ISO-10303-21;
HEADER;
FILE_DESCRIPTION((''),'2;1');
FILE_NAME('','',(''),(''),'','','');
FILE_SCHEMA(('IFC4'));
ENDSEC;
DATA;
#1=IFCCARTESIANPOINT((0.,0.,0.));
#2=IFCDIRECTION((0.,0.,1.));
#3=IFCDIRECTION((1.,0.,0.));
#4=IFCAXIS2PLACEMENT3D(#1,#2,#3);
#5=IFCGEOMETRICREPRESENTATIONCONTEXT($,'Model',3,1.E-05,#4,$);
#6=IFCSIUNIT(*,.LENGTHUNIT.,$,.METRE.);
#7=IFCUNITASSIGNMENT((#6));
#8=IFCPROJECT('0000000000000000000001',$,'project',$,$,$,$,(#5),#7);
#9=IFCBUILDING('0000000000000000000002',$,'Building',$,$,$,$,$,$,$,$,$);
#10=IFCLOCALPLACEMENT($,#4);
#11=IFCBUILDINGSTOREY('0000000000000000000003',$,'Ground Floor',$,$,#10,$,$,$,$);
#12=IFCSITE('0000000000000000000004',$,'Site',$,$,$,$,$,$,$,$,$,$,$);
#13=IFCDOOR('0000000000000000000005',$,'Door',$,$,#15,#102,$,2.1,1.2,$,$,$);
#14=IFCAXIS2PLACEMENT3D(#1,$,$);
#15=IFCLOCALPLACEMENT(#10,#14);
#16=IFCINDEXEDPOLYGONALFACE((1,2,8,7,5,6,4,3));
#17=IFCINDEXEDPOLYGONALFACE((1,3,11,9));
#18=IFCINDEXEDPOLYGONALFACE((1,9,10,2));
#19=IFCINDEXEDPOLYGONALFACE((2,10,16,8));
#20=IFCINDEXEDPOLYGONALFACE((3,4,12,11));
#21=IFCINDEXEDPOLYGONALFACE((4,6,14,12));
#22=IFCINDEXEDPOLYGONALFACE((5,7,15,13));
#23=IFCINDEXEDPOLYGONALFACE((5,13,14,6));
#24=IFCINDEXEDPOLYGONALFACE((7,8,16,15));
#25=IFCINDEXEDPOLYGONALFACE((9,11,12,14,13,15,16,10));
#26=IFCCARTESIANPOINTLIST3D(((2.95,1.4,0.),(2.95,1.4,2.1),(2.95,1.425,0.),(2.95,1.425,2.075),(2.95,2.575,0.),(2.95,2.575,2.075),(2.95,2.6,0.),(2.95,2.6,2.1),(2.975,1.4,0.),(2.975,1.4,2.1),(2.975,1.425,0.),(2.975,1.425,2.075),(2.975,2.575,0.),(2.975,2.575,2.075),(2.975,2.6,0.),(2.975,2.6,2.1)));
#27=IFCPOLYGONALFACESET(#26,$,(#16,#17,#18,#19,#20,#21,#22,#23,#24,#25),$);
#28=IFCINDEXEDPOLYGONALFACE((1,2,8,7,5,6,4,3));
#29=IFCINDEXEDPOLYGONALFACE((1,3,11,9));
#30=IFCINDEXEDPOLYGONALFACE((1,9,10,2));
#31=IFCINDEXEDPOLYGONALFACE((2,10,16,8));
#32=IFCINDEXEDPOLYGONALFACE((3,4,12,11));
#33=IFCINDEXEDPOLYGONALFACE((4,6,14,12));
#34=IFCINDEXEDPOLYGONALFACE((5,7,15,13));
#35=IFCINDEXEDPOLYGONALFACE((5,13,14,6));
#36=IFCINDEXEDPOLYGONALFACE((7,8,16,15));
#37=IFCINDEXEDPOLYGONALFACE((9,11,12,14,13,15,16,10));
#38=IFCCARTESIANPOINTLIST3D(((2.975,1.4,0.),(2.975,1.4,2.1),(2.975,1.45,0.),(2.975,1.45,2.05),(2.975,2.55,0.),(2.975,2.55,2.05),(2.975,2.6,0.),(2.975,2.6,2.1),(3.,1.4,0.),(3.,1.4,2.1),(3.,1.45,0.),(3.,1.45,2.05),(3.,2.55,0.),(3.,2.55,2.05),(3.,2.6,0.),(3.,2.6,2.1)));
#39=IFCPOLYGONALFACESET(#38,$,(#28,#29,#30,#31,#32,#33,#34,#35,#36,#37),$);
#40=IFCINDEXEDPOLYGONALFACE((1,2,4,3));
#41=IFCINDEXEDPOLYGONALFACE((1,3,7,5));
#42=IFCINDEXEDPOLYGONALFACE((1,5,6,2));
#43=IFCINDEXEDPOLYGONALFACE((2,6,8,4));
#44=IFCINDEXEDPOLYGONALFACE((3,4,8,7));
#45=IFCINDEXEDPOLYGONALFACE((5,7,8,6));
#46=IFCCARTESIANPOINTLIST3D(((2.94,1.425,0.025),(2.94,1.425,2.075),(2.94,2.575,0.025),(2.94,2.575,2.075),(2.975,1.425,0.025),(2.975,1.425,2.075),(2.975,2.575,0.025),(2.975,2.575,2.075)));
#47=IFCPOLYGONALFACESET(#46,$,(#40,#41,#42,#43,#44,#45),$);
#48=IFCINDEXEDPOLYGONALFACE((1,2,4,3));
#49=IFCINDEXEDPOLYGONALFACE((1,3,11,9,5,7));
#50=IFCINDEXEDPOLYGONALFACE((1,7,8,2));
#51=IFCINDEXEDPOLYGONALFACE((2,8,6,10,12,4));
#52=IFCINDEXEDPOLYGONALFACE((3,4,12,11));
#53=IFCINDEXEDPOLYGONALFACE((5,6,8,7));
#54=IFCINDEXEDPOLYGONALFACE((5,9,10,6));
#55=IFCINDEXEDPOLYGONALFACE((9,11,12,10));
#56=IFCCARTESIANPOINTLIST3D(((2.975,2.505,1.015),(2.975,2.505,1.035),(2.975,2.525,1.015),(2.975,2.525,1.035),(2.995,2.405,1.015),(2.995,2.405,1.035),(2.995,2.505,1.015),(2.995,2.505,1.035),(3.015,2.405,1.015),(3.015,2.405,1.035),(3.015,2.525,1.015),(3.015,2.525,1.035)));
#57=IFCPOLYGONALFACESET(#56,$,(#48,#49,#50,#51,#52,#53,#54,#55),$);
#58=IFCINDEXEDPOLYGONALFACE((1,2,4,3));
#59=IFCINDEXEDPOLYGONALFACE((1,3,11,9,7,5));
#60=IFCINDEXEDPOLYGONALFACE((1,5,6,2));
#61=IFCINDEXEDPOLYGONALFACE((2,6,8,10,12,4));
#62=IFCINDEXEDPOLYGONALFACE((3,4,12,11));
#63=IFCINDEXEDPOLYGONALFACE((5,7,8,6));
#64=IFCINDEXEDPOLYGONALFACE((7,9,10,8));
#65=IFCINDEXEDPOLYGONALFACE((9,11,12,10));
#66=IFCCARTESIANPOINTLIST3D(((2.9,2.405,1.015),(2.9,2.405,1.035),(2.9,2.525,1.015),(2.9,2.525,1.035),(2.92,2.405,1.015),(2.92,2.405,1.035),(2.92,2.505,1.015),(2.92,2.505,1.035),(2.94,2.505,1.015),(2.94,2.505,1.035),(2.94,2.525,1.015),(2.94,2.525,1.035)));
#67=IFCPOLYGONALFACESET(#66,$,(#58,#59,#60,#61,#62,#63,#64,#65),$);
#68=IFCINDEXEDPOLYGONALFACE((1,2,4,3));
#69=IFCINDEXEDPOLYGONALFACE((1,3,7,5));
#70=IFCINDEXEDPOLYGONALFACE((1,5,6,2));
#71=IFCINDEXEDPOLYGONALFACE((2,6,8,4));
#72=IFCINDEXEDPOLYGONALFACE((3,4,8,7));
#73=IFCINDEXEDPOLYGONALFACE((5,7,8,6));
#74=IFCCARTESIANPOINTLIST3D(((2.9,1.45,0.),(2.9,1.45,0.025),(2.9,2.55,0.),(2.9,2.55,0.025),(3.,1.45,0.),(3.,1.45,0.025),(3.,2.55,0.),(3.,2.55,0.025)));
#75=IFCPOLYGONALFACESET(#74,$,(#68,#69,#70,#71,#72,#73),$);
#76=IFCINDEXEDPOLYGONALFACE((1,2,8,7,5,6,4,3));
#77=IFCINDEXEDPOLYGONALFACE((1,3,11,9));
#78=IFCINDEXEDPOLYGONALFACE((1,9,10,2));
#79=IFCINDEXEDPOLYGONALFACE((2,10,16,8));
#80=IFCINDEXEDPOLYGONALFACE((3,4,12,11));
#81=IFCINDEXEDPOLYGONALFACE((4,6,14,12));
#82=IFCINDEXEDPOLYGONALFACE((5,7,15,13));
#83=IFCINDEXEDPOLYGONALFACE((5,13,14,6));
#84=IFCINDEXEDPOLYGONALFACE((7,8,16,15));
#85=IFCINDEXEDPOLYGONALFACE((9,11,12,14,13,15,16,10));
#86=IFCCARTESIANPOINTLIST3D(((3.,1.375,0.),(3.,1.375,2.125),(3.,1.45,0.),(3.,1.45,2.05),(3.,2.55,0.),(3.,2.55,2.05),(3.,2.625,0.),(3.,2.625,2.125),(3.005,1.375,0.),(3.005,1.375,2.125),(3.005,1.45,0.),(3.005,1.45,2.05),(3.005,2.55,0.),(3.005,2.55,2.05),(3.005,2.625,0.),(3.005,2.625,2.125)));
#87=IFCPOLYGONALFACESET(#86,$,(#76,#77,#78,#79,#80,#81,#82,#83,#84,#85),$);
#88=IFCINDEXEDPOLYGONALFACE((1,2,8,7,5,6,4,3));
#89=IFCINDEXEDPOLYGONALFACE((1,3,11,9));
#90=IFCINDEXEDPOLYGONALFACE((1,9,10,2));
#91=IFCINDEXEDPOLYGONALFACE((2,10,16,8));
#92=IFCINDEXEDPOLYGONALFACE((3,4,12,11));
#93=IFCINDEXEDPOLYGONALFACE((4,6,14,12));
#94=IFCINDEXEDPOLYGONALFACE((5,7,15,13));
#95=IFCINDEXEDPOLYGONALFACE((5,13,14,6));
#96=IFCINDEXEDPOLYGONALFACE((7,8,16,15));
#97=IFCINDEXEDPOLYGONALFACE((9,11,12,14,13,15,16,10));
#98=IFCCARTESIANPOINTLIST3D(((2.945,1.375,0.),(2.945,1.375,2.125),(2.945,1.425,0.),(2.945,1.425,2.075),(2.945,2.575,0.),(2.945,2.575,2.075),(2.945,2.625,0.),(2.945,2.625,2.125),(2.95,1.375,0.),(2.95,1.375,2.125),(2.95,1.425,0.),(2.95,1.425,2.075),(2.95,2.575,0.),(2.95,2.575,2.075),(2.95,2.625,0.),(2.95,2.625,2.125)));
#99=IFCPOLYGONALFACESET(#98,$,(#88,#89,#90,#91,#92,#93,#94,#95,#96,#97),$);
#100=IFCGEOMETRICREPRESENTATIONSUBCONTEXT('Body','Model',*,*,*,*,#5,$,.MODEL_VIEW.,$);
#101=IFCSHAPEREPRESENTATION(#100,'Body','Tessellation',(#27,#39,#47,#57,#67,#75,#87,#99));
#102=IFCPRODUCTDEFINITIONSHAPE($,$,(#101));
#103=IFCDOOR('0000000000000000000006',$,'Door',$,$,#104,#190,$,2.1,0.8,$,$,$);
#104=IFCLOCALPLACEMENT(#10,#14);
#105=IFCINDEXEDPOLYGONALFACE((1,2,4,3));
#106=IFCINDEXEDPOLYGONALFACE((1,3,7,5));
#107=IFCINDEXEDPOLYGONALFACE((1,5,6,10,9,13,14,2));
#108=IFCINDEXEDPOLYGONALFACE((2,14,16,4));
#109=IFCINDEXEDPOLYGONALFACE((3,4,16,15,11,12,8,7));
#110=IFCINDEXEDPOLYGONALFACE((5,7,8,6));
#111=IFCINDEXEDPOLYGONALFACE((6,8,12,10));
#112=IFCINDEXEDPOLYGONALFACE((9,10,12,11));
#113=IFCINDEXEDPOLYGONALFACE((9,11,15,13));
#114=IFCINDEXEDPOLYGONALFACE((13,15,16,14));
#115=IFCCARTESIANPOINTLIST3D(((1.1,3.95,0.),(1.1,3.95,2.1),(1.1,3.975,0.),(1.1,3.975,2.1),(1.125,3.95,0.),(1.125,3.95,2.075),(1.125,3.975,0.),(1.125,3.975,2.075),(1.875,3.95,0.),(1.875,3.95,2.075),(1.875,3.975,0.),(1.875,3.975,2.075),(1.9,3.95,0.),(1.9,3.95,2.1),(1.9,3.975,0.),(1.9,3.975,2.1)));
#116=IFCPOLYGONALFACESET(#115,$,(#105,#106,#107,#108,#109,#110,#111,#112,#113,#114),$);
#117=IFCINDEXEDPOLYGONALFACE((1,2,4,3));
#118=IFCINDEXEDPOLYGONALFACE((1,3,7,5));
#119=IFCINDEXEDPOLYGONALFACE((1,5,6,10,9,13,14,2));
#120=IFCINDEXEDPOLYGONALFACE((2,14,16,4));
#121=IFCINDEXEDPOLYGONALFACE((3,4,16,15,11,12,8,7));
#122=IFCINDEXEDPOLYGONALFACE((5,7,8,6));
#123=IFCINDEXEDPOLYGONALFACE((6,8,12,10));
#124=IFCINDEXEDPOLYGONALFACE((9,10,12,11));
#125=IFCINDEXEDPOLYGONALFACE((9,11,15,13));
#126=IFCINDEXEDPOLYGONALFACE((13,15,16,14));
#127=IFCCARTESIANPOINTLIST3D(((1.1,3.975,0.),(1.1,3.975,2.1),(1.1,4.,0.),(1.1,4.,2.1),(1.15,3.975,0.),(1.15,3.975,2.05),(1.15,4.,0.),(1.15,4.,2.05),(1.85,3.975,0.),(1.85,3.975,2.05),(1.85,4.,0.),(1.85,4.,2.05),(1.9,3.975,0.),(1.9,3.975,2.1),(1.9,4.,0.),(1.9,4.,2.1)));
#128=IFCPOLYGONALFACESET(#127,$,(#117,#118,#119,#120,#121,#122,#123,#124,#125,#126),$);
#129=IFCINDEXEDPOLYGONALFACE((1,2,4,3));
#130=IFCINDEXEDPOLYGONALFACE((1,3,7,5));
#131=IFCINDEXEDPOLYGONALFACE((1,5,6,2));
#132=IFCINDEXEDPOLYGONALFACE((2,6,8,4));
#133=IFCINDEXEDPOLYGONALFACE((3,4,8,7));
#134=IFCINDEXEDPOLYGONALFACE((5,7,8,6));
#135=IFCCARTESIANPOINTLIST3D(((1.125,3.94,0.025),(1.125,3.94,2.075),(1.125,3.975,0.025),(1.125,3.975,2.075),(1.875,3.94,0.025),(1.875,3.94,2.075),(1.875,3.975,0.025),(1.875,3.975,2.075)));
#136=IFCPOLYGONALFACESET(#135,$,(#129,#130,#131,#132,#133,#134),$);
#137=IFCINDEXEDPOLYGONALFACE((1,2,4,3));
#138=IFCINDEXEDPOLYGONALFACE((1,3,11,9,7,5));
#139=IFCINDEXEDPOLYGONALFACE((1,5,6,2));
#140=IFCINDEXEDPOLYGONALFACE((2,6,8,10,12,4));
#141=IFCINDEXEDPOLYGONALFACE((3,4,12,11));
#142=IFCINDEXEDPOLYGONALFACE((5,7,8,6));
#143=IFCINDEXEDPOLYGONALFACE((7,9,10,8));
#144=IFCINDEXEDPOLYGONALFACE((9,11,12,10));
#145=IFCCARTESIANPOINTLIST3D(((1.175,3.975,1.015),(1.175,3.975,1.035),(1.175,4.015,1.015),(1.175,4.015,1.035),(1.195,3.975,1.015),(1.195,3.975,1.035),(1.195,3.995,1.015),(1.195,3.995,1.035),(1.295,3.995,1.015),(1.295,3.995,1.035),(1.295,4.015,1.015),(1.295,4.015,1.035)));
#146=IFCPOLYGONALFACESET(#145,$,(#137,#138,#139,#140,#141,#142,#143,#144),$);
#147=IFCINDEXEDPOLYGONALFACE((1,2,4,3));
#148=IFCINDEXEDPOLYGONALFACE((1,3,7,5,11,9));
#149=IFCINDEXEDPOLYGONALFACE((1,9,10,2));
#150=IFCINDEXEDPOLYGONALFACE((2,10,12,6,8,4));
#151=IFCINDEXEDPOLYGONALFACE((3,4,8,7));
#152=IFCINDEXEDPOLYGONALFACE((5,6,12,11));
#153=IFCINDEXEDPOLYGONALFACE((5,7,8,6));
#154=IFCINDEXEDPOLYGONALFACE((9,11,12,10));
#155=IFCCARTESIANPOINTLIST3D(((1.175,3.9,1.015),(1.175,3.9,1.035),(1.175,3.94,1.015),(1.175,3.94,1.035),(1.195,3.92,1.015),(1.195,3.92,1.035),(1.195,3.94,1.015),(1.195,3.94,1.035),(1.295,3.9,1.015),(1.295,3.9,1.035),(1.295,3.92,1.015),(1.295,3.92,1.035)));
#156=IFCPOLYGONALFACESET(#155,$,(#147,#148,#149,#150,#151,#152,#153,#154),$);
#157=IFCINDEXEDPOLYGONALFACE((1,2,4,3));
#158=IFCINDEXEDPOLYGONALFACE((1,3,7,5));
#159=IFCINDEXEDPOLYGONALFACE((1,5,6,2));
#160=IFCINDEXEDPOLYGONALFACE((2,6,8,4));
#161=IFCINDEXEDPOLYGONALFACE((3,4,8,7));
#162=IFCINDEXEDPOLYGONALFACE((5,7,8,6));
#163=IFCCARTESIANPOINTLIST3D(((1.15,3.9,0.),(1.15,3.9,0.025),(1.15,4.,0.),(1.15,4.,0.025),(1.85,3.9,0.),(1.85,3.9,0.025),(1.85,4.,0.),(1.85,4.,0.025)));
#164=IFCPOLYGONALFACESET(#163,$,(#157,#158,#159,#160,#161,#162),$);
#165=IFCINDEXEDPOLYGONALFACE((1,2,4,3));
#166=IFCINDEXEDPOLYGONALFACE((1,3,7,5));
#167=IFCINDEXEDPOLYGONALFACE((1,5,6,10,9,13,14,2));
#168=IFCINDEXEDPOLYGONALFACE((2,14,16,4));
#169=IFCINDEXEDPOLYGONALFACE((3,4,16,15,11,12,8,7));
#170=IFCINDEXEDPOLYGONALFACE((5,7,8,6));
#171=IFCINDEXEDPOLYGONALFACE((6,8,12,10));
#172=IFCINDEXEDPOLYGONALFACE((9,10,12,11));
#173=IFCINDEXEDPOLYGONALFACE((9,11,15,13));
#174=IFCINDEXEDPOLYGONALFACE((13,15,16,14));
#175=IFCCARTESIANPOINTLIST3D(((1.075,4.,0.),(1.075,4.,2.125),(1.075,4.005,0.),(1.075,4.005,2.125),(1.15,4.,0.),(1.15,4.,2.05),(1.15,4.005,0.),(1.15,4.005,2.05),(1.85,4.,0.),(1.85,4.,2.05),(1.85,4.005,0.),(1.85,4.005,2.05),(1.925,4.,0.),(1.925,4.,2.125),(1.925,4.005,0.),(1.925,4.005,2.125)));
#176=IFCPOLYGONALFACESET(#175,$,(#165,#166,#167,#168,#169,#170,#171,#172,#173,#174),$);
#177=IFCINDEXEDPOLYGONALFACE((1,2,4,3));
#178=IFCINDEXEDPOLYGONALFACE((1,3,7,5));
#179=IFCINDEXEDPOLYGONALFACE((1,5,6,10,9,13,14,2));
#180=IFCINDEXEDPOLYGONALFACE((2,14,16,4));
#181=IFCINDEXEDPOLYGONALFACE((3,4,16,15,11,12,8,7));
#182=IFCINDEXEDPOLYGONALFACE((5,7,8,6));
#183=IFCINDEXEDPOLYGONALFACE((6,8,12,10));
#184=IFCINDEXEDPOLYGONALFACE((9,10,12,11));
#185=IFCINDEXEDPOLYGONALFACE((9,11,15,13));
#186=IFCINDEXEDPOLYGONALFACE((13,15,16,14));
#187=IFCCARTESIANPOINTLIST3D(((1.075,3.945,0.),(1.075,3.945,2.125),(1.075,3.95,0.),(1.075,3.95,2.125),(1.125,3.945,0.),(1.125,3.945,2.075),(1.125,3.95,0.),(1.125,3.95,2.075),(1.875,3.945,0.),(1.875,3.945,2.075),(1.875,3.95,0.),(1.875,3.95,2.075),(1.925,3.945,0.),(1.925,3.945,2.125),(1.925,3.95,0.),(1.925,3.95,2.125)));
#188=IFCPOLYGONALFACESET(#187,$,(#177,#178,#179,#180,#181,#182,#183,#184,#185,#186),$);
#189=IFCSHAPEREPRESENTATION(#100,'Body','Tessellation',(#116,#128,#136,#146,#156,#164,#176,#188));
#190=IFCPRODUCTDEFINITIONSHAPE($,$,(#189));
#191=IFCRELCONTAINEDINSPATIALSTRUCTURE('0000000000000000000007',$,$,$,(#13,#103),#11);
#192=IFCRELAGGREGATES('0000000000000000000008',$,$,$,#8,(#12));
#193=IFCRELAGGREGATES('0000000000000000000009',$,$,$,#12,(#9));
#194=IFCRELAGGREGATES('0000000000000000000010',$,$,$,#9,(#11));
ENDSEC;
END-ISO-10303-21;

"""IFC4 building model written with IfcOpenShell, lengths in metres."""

from ifc_helpers import new_model, si_unit, frame, origin_with_axes, place, context, subcontext, project, spatial, line, indexed_curve, outline, extrude, element, save


model = new_model("IFC4")

# Units and contexts
model_context = context("Model", 3, precision=1e-05, world=origin_with_axes())
body_context = subcontext(model_context, "Body", "Model", "MODEL_VIEW")
ifc_project = project(units=[si_unit("LENGTHUNIT", "METRE")], contexts=[model_context])

# Site, building, storey
site = spatial("IfcSite", under=ifc_project, Name="Site")
building = spatial("IfcBuilding", under=site, Name="Building")
storey_placement = place(None, origin_with_axes())
storey = spatial("IfcBuildingStorey", under=building, at=storey_placement, Name="Ground Floor")

# Doors
door_1_placement = place(storey_placement, frame((3.0, 1.4, 0.0), z_axis=(0.0, 0.0, 1.0), x_axis=(0.0, 1.0, 0.0)))
element("IfcDoor", 1, at=door_1_placement, inside=storey, Name="Door", OverallHeight=2.1, OverallWidth=1.2, context=body_context, shape_type="SweptSolid", body=[
    extrude(outline(indexed_curve([(0.0, 0.0), (0.0, 2.1), (1.2, 2.1), (1.2, 0.0), (1.175, 0.0), (1.175, 2.075), (0.025, 2.075), (0.025, 0.0)], segments=[line(1, 2, 3, 4, 5, 6, 7, 8, 1)])), frame((0.0, 0.025, 0.0), z_axis=(0.0, -1.0, 0.0), x_axis=(1.0, 0.0, 0.0)), (0.0, 0.0, -1.0), 0.025),
    extrude(outline(indexed_curve([(0.0, 0.0), (0.0, 2.1), (1.2, 2.1), (1.2, 0.0), (1.15, 0.0), (1.15, 2.05), (0.05, 2.05), (0.05, 0.0)], segments=[line(1, 2, 3, 4, 5, 6, 7, 8, 1)])), frame((0.0, 0.0, 0.0), z_axis=(0.0, -1.0, 0.0), x_axis=(1.0, 0.0, 0.0)), (0.0, 0.0, -1.0), 0.025),
    extrude(outline(indexed_curve([(0.0, 0.0), (1.15, 0.0), (1.15, 0.035), (0.0, 0.035)], segments=[line(1, 2, 3, 4, 1)])), frame((0.025, 0.025, 0.025), z_axis=(0.0, 0.0, 1.0), x_axis=(1.0, 0.0, 0.0)), (0.0, 0.0, 1.0), 2.05),
    extrude(outline(indexed_curve([(0.0, 0.0), (0.0, -0.04), (-0.12, -0.04), (-0.12, -0.02), (-0.02, -0.02), (-0.02, 0.0)], segments=[line(1, 2, 3, 4, 5, 6, 1)])), frame((1.125, 0.025, 1.015), z_axis=(0.0, 0.0, 1.0), x_axis=(1.0, 0.0, 0.0)), (0.0, 0.0, 1.0), 0.02),
    extrude(outline(indexed_curve([(0.0, 0.0), (0.0, 0.04), (-0.12, 0.04), (-0.12, 0.02), (-0.02, 0.02), (-0.02, 0.0)], segments=[line(1, 2, 3, 4, 5, 6, 1)])), frame((1.125, 0.06, 1.015), z_axis=(0.0, 0.0, 1.0), x_axis=(1.0, 0.0, 0.0)), (0.0, 0.0, 1.0), 0.02),
    extrude(outline(indexed_curve([(0.0, 0.0), (1.1, 0.0), (1.1, 0.1), (0.0, 0.1)], segments=[line(1, 2, 3, 4, 1)])), frame((0.05, 0.0, 0.0), z_axis=(0.0, 0.0, 1.0), x_axis=(1.0, 0.0, 0.0)), (0.0, 0.0, 1.0), 0.025),
    extrude(outline(indexed_curve([(0.0, 0.0), (0.0, 2.125), (1.25, 2.125), (1.25, 0.0), (1.175, 0.0), (1.175, 2.05), (0.075, 2.05), (0.075, 0.0)], segments=[line(1, 2, 3, 4, 5, 6, 7, 8, 1)])), frame((-0.025, -0.005, 0.0), z_axis=(0.0, -1.0, 0.0), x_axis=(1.0, 0.0, 0.0)), (0.0, 0.0, -1.0), 0.005),
    extrude(outline(indexed_curve([(0.0, 0.0), (0.0, 2.125), (1.25, 2.125), (1.25, 0.0), (1.2, 0.0), (1.2, 2.075), (0.05, 2.075), (0.05, 0.0)], segments=[line(1, 2, 3, 4, 5, 6, 7, 8, 1)])), frame((-0.025, 0.05, 0.0), z_axis=(0.0, -1.0, 0.0), x_axis=(1.0, 0.0, 0.0)), (0.0, 0.0, -1.0), 0.005),
])
door_2_placement = place(storey_placement, frame((1.9, 4.0, 0.0), z_axis=(0.0, 0.0, 1.0), x_axis=(-1.0, 0.0, 0.0)))
element("IfcDoor", 2, at=door_2_placement, inside=storey, Name="Door", OverallHeight=2.1, OverallWidth=0.8, context=body_context, shape_type="SweptSolid", body=[
    extrude(outline(indexed_curve([(0.0, 0.0), (0.0, 2.1), (0.8, 2.1), (0.8, 0.0), (0.775, 0.0), (0.775, 2.075), (0.025, 2.075), (0.025, 0.0)], segments=[line(1, 2, 3, 4, 5, 6, 7, 8, 1)])), frame((0.0, 0.025, 0.0), z_axis=(0.0, -1.0, 0.0), x_axis=(1.0, 0.0, 0.0)), (0.0, 0.0, -1.0), 0.025),
    extrude(outline(indexed_curve([(0.0, 0.0), (0.0, 2.1), (0.8, 2.1), (0.8, 0.0), (0.75, 0.0), (0.75, 2.05), (0.05, 2.05), (0.05, 0.0)], segments=[line(1, 2, 3, 4, 5, 6, 7, 8, 1)])), frame((0.0, 0.0, 0.0), z_axis=(0.0, -1.0, 0.0), x_axis=(1.0, 0.0, 0.0)), (0.0, 0.0, -1.0), 0.025),
    extrude(outline(indexed_curve([(0.0, 0.0), (0.75, 0.0), (0.75, 0.035), (0.0, 0.035)], segments=[line(1, 2, 3, 4, 1)])), frame((0.025, 0.025, 0.025), z_axis=(0.0, 0.0, 1.0), x_axis=(1.0, 0.0, 0.0)), (0.0, 0.0, 1.0), 2.05),
    extrude(outline(indexed_curve([(0.0, 0.0), (0.0, -0.04), (-0.12, -0.04), (-0.12, -0.02), (-0.02, -0.02), (-0.02, 0.0)], segments=[line(1, 2, 3, 4, 5, 6, 1)])), frame((0.725, 0.025, 1.015), z_axis=(0.0, 0.0, 1.0), x_axis=(1.0, 0.0, 0.0)), (0.0, 0.0, 1.0), 0.02),
    extrude(outline(indexed_curve([(0.0, 0.0), (0.0, 0.04), (-0.12, 0.04), (-0.12, 0.02), (-0.02, 0.02), (-0.02, 0.0)], segments=[line(1, 2, 3, 4, 5, 6, 1)])), frame((0.725, 0.06, 1.015), z_axis=(0.0, 0.0, 1.0), x_axis=(1.0, 0.0, 0.0)), (0.0, 0.0, 1.0), 0.02),
    extrude(outline(indexed_curve([(0.0, 0.0), (0.7, 0.0), (0.7, 0.1), (0.0, 0.1)], segments=[line(1, 2, 3, 4, 1)])), frame((0.05, 0.0, 0.0), z_axis=(0.0, 0.0, 1.0), x_axis=(1.0, 0.0, 0.0)), (0.0, 0.0, 1.0), 0.025),
    extrude(outline(indexed_curve([(0.0, 0.0), (0.0, 2.125), (0.85, 2.125), (0.85, 0.0), (0.775, 0.0), (0.775, 2.05), (0.075, 2.05), (0.075, 0.0)], segments=[line(1, 2, 3, 4, 5, 6, 7, 8, 1)])), frame((-0.025, -0.005, 0.0), z_axis=(0.0, -1.0, 0.0), x_axis=(1.0, 0.0, 0.0)), (0.0, 0.0, -1.0), 0.005),
    extrude(outline(indexed_curve([(0.0, 0.0), (0.0, 2.125), (0.85, 2.125), (0.85, 0.0), (0.8, 0.0), (0.8, 2.075), (0.05, 2.075), (0.05, 0.0)], segments=[line(1, 2, 3, 4, 5, 6, 7, 8, 1)])), frame((-0.025, 0.05, 0.0), z_axis=(0.0, -1.0, 0.0), x_axis=(1.0, 0.0, 0.0)), (0.0, 0.0, -1.0), 0.005),
])

save(model, "model.ifc")
